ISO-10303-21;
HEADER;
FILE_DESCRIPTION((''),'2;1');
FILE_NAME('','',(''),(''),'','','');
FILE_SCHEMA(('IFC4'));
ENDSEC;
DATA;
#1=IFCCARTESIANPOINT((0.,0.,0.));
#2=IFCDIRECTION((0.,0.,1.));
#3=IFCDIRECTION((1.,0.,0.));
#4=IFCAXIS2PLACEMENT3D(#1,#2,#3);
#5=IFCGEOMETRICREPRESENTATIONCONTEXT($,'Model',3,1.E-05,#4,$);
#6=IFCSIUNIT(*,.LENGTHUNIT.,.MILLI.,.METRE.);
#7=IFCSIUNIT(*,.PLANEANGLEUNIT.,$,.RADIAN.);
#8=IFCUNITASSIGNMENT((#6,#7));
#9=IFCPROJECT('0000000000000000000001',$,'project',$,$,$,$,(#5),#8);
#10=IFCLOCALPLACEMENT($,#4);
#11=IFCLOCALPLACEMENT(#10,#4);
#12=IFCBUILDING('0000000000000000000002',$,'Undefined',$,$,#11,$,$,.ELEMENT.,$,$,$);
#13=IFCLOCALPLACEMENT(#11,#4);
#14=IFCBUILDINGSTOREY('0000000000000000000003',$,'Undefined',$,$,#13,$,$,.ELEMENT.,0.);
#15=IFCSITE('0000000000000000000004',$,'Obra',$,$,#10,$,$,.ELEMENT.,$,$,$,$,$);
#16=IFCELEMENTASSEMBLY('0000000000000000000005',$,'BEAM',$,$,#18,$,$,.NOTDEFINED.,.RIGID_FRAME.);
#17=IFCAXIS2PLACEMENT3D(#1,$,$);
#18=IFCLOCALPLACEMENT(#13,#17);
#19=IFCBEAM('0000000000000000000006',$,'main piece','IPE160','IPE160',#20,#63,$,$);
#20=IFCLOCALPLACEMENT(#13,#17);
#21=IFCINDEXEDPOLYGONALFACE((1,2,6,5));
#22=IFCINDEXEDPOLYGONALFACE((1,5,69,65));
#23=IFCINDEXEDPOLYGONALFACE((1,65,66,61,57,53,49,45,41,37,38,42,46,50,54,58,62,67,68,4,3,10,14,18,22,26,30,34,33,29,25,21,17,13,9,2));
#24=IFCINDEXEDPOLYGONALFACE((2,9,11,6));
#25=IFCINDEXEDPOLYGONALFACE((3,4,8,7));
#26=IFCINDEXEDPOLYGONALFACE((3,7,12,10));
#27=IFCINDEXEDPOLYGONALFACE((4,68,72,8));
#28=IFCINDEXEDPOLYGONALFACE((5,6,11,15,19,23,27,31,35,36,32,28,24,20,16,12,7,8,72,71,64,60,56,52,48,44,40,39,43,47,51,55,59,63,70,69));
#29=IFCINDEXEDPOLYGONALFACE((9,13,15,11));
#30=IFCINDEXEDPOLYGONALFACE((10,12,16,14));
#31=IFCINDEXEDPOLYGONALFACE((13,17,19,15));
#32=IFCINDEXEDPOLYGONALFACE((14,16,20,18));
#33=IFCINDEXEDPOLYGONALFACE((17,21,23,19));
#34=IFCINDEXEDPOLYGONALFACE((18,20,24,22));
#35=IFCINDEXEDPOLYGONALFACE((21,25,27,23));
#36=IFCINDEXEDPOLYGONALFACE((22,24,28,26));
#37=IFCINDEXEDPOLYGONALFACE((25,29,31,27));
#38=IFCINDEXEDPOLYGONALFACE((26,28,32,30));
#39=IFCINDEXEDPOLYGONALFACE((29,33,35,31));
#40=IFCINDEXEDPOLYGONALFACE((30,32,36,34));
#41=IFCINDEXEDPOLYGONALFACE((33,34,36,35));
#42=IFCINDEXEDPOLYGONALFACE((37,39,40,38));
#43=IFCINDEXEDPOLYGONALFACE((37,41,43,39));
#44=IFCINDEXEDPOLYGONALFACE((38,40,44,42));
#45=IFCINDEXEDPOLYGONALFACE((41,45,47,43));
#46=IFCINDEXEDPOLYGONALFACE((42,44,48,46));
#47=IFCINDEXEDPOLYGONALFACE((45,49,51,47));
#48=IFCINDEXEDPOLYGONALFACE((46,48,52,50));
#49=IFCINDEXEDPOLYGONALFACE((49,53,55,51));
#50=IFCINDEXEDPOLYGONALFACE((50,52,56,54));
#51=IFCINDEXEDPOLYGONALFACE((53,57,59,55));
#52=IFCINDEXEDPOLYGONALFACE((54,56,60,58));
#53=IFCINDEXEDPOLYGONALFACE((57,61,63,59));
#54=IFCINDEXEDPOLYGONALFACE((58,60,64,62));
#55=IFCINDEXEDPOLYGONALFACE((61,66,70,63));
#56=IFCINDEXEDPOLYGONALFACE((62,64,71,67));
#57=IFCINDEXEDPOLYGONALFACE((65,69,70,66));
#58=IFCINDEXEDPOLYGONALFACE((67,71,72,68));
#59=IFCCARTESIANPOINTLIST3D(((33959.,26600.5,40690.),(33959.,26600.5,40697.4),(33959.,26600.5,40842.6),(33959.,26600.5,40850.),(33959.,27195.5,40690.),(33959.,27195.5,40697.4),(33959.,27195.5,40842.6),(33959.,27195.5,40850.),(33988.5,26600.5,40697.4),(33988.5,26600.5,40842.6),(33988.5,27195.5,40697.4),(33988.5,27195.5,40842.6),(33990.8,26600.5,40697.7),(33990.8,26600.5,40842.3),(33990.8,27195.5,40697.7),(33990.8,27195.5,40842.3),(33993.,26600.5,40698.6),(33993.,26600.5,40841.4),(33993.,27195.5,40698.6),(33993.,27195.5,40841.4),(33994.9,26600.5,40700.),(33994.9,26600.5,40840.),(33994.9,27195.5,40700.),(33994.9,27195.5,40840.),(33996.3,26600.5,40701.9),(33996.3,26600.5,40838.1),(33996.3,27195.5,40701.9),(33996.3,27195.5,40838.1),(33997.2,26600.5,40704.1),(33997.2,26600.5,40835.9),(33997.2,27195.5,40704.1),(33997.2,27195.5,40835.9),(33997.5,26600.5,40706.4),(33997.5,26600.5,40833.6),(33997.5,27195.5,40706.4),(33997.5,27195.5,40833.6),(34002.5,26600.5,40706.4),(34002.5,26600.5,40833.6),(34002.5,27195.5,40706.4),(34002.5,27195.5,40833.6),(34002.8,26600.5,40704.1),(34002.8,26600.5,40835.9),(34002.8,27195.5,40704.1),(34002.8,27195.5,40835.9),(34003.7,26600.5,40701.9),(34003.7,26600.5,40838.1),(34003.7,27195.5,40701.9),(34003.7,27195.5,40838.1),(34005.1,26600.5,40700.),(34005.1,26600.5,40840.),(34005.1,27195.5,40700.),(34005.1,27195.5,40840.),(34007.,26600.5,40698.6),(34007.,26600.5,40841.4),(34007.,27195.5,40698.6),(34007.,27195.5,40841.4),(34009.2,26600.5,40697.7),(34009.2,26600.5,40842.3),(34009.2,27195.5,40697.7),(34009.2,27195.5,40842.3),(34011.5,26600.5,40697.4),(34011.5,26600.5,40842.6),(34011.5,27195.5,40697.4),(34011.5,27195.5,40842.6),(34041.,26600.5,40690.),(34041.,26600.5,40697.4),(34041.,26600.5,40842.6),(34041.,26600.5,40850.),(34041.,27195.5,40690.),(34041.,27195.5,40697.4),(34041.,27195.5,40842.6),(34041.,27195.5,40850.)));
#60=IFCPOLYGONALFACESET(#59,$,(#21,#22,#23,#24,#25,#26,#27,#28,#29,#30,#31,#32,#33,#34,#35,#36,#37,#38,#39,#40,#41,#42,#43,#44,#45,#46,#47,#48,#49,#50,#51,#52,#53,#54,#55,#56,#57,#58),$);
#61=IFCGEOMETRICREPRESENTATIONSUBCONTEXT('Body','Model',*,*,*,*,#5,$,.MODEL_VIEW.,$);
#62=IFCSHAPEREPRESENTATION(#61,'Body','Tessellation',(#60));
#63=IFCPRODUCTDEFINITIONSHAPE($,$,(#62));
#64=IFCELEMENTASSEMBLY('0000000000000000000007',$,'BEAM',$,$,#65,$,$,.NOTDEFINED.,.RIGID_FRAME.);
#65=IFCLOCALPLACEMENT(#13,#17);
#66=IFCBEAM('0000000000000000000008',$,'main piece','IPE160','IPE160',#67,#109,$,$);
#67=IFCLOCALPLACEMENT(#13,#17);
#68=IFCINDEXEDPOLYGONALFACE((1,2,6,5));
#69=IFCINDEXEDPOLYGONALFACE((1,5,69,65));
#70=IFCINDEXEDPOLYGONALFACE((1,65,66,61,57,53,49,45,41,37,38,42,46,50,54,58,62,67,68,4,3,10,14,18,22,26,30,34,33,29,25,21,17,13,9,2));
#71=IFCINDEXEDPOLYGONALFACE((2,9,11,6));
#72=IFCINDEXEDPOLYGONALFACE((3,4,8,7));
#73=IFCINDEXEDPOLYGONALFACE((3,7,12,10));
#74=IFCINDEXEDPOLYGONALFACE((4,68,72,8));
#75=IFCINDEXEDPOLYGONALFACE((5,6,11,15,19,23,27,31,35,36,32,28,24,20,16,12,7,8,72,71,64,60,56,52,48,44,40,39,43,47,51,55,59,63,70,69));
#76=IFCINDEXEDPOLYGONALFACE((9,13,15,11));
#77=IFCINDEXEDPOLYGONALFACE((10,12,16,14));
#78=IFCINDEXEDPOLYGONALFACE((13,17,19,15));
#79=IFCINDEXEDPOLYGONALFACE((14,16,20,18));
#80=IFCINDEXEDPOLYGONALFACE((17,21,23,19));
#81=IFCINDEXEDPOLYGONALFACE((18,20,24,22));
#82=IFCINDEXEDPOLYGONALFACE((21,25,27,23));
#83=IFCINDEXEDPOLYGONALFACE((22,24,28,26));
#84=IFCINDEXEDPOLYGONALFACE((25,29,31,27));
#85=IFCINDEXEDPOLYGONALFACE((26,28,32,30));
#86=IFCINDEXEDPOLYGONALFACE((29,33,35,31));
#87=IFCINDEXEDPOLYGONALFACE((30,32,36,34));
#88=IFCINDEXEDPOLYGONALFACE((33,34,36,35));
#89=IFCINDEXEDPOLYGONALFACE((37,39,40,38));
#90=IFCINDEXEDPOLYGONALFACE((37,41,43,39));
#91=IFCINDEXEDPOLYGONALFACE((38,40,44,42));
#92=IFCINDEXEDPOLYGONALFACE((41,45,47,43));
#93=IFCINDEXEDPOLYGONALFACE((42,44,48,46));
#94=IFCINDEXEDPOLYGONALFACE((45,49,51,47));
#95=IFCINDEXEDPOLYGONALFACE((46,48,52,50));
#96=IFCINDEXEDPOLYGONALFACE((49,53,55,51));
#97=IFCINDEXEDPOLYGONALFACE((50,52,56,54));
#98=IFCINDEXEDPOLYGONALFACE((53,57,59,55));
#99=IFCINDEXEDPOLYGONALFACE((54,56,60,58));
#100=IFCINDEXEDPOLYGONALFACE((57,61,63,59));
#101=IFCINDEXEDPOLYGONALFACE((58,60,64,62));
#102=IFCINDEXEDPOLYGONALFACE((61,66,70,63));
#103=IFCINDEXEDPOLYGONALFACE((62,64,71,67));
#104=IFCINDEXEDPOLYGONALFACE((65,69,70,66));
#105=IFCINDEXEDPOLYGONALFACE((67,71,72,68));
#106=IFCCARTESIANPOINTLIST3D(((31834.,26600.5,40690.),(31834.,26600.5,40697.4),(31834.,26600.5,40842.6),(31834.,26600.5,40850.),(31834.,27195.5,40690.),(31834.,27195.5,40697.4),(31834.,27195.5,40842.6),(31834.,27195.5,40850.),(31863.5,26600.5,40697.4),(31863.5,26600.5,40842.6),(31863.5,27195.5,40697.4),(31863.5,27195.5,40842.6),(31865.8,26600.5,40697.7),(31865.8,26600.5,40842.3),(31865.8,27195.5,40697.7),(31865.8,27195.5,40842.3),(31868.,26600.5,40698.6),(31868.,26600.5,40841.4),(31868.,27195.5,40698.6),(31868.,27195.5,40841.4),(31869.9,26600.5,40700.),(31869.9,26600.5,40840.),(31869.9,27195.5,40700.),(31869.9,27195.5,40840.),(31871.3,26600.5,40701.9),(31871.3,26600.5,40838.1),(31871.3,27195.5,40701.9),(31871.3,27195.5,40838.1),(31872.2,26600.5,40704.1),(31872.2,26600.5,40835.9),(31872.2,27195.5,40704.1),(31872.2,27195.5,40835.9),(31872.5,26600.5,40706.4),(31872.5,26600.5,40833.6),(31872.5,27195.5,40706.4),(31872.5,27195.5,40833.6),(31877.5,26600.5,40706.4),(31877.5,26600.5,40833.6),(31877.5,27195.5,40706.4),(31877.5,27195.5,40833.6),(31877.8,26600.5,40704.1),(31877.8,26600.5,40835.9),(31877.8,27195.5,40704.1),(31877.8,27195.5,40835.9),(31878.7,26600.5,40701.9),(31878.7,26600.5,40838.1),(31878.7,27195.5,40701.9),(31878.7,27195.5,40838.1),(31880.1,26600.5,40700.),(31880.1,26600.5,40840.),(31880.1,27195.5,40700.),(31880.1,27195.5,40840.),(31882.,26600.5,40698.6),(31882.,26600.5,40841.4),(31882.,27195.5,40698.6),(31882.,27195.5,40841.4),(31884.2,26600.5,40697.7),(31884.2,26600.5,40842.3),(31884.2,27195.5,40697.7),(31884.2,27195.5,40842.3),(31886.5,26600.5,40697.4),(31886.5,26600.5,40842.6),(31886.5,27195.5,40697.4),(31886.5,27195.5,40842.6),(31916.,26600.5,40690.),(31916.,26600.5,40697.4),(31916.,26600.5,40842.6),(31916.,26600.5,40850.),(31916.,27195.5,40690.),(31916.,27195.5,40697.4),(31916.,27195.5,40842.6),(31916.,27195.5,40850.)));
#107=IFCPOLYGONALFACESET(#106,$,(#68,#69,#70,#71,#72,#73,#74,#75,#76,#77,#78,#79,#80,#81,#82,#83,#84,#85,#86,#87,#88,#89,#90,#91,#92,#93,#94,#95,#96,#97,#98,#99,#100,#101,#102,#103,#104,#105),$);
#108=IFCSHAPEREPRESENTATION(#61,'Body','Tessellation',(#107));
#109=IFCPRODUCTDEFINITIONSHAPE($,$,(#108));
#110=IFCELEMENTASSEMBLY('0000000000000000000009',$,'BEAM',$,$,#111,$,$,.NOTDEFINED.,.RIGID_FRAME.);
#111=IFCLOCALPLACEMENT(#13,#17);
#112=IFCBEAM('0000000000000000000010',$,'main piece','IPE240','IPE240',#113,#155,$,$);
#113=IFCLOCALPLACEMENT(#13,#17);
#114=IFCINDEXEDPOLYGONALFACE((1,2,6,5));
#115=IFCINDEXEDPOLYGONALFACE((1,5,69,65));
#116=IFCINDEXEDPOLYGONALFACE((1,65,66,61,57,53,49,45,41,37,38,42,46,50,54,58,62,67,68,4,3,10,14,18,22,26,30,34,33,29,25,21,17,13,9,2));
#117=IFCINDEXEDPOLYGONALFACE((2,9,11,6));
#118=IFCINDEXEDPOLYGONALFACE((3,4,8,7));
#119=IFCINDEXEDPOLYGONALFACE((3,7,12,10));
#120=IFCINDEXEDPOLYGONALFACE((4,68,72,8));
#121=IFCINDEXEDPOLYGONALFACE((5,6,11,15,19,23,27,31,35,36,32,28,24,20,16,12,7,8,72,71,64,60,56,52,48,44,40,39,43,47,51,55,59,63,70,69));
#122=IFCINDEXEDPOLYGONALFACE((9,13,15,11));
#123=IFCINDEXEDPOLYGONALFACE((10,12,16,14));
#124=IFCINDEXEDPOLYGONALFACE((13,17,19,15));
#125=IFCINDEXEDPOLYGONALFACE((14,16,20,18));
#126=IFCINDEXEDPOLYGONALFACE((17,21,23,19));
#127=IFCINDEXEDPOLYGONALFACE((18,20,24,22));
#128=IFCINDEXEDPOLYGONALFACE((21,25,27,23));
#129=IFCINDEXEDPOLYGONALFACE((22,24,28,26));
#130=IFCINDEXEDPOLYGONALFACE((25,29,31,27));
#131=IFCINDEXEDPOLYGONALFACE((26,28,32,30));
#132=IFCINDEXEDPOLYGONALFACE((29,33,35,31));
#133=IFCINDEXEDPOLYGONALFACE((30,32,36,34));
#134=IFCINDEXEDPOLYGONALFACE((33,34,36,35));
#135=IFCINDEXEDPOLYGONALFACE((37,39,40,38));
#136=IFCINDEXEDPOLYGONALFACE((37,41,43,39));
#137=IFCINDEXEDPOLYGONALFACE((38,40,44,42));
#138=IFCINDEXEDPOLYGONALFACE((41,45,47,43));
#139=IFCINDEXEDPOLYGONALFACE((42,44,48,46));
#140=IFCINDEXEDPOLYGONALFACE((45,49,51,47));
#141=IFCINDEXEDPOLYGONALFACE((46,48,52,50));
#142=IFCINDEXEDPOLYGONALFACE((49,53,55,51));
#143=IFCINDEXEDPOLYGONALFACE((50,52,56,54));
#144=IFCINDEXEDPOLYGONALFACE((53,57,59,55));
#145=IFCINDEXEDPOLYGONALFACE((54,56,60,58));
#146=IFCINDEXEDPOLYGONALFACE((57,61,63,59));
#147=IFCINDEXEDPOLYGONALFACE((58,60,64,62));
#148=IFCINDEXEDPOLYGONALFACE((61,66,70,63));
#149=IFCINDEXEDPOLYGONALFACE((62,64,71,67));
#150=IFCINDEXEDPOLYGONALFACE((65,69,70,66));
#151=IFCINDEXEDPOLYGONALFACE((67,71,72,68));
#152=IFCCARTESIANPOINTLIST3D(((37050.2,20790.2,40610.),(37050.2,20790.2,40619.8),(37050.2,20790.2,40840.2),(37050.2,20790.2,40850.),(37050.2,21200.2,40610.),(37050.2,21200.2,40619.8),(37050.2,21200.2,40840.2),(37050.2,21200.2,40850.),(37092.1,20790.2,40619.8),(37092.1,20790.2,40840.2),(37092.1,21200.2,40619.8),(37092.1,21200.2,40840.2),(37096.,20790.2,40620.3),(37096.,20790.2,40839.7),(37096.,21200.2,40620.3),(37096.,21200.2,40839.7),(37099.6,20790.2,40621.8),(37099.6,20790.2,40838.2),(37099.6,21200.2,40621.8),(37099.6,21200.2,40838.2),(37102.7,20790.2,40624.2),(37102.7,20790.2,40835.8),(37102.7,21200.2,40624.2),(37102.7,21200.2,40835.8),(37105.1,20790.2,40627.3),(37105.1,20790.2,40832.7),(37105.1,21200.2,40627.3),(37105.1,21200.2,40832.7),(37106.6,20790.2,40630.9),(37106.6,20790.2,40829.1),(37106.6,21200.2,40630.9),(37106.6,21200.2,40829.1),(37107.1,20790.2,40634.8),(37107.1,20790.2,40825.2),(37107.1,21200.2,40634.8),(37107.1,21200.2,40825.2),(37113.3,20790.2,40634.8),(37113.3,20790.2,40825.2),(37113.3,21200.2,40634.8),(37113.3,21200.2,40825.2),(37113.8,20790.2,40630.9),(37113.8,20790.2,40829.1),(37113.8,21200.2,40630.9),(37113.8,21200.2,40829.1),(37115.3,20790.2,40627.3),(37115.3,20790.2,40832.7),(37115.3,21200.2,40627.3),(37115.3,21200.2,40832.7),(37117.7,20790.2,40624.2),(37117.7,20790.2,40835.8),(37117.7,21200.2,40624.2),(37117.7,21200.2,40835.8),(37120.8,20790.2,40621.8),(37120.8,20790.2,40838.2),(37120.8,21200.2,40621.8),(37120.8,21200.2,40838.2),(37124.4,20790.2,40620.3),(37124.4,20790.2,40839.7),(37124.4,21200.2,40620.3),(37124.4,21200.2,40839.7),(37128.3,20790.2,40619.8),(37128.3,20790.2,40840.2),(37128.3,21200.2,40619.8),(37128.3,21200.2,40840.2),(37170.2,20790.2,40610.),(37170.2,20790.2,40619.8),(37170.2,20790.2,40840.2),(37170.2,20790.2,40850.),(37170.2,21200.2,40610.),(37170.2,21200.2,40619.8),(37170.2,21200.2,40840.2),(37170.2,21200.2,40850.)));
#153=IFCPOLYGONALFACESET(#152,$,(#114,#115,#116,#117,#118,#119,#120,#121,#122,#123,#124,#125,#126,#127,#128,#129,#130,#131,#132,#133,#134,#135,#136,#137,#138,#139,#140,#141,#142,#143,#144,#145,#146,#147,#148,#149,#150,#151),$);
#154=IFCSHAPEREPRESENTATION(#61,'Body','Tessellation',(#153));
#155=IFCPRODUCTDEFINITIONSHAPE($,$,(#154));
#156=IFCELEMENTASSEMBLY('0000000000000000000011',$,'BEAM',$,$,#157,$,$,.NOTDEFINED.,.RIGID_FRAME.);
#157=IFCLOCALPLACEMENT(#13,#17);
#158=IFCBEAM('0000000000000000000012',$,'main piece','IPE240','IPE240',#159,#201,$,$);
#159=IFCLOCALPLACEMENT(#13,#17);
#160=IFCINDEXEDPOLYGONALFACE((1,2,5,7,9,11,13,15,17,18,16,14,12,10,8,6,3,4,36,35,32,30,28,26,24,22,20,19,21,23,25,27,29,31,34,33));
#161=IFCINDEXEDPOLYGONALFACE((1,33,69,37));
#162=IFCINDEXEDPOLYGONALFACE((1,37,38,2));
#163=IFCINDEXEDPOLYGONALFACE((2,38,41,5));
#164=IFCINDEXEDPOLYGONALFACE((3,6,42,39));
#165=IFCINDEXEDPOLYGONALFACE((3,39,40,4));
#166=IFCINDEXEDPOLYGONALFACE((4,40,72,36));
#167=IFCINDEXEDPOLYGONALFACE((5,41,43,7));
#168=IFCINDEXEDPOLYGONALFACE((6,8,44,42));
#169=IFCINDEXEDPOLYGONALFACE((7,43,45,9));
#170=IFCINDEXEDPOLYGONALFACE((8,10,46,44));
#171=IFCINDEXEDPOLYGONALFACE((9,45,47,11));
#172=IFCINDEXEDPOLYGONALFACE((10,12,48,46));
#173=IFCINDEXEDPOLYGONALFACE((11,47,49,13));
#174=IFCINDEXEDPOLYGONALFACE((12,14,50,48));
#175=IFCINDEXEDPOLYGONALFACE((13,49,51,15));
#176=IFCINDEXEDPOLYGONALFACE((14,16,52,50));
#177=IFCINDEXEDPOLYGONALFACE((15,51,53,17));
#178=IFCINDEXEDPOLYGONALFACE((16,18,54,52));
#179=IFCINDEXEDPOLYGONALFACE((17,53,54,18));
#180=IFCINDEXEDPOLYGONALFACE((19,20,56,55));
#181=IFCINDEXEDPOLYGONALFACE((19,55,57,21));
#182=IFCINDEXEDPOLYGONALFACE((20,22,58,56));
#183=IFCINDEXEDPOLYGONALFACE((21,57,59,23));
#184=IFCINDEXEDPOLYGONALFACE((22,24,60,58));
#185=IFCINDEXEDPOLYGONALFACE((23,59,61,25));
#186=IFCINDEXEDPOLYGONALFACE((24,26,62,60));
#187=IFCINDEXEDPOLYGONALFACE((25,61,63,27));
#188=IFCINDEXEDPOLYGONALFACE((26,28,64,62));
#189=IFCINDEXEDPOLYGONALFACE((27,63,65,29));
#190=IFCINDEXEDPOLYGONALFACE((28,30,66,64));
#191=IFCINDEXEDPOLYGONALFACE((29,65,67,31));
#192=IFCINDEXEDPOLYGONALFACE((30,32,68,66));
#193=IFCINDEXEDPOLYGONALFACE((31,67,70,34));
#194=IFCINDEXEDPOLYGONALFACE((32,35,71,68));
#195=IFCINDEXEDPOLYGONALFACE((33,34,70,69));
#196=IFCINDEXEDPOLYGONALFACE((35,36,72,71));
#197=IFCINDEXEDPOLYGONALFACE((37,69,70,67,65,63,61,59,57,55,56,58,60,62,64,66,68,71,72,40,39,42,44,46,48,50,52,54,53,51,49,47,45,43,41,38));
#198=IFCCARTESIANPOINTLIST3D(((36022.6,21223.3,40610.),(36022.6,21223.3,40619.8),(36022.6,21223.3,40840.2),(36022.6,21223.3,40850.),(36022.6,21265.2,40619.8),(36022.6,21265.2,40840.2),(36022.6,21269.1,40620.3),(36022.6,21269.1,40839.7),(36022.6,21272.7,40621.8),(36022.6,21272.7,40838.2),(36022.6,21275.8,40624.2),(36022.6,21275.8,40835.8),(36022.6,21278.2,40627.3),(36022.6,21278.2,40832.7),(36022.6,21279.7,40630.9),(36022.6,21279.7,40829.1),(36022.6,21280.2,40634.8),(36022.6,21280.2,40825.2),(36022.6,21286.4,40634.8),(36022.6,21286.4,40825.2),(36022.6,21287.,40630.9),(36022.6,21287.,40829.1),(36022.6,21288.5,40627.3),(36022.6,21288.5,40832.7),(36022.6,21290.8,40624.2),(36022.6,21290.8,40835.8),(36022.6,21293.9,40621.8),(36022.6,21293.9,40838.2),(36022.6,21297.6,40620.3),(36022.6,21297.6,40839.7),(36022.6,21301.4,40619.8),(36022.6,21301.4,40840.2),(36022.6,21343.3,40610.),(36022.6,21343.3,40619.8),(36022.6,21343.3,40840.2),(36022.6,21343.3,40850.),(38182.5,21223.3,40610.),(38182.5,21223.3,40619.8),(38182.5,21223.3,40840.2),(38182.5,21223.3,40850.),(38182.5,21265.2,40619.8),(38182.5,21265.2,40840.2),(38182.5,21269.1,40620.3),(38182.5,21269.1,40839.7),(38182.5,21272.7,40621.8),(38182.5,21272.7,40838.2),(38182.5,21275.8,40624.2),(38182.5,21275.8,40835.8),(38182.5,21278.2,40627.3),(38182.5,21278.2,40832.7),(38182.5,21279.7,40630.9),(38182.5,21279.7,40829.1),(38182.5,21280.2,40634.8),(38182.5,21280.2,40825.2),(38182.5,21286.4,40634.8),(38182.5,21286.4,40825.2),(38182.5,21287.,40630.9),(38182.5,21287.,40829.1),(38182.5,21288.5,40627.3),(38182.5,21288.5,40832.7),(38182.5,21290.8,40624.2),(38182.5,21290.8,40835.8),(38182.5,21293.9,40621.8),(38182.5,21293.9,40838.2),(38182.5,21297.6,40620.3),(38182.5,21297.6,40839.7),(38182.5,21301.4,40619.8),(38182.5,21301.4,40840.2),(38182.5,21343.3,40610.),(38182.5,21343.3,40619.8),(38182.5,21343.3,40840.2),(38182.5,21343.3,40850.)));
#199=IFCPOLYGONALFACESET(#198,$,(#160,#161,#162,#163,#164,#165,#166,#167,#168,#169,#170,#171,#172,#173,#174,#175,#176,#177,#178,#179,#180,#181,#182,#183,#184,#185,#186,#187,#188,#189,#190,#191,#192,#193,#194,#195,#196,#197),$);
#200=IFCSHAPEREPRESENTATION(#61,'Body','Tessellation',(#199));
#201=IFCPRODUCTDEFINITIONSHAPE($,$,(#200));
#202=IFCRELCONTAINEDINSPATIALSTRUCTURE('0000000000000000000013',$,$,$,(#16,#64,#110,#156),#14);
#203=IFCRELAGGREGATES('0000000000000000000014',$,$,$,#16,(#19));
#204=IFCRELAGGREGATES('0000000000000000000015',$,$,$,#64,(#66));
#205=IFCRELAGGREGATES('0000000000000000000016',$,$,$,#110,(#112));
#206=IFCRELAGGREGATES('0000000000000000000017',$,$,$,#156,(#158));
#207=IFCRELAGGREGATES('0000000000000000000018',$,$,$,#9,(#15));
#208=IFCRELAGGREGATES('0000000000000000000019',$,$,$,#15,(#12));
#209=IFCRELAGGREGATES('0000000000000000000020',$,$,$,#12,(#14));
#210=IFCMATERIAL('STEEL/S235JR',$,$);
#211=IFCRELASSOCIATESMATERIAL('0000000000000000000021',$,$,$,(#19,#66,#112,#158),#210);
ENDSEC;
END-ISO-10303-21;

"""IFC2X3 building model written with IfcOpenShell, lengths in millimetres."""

from ifc_helpers import new_model, si_unit, frame, origin_with_axes, origin_2d_with_axis, place, context, subcontext, project, spatial, i_section, extrude, material, element, aggregate, save


model = new_model("IFC2X3")

# Units and contexts
model_context = context("Model", 3, precision=1e-05, world=origin_with_axes())
body_context = subcontext(model_context, "Body", "Model", "MODEL_VIEW")
ifc_project = project(units=[si_unit("LENGTHUNIT", "METRE", prefix="MILLI"), si_unit("PLANEANGLEUNIT", "RADIAN")], contexts=[model_context])

# Site, building, storey
site_placement = place(None, origin_with_axes())
site = spatial("IfcSite", under=ifc_project, at=site_placement, Name="Obra", CompositionType="ELEMENT")
building_placement = place(site_placement, origin_with_axes())
building = spatial("IfcBuilding", under=site, at=building_placement, Name="Undefined", CompositionType="ELEMENT")
storey_placement = place(building_placement, origin_with_axes())
storey = spatial("IfcBuildingStorey", under=building, at=storey_placement, Name="Undefined", CompositionType="ELEMENT", Elevation=0.0)

# Element assemblies, beams
ifc_material_1 = material(Name="STEEL/S235JR")
assembly_1_placement = place(storey_placement, origin_with_axes())
assembly_1 = element("IfcElementAssembly", 1, at=assembly_1_placement, inside=storey, Name="BEAM", AssemblyPlace="NOTDEFINED", PredefinedType="RIGID_FRAME")
beam_1_placement = place(assembly_1_placement, frame((34000.0, 26600.5, 40770.0), z_axis=(0.0, 0.0, 1.0), x_axis=(0.0, 1.0, 0.0)))
beam_1 = element("IfcBeam", 2, at=beam_1_placement, material=ifc_material_1, Name="main piece", Description="IPE160", ObjectType="IPE160", context=body_context, shape_type="SweptSolid", body=[
    extrude(i_section(OverallWidth=82.0, OverallDepth=160.0, WebThickness=5.0, FlangeThickness=7.4, FilletRadius=9.0, at=origin_2d_with_axis()), frame((595.1, 0.0, 0.0), z_axis=(-1.0, 0.0, 0.0), x_axis=(0.0, -1.0, 0.0)), (0.0, 0.0, 1.0), 595.0),
])
aggregate(assembly_1, [beam_1])
assembly_2_placement = place(storey_placement, origin_with_axes())
assembly_2 = element("IfcElementAssembly", 3, at=assembly_2_placement, inside=storey, Name="BEAM", AssemblyPlace="NOTDEFINED", PredefinedType="RIGID_FRAME")
beam_2_placement = place(assembly_2_placement, frame((31875.0, 26600.5, 40770.0), z_axis=(0.0, 0.0, 1.0), x_axis=(0.0, 1.0, 0.0)))
beam_2 = element("IfcBeam", 4, at=beam_2_placement, material=ifc_material_1, Name="main piece", Description="IPE160", ObjectType="IPE160", context=body_context, shape_type="SweptSolid", body=[
    extrude(i_section(OverallWidth=82.0, OverallDepth=160.0, WebThickness=5.0, FlangeThickness=7.4, FilletRadius=9.0, at=origin_2d_with_axis()), frame((595.0, 0.0, 0.0), z_axis=(-1.0, 0.0, 0.0), x_axis=(0.0, -1.0, 0.0)), (0.0, 0.0, 1.0), 595.0),
])
aggregate(assembly_2, [beam_2])
assembly_3_placement = place(storey_placement, origin_with_axes())
assembly_3 = element("IfcElementAssembly", 5, at=assembly_3_placement, inside=storey, Name="BEAM", AssemblyPlace="NOTDEFINED", PredefinedType="RIGID_FRAME")
beam_3_placement = place(assembly_3_placement, frame((37110.2, 20790.2, 40730.0), z_axis=(0.0, 0.0, 1.0), x_axis=(0.0, 1.0, 0.0)))
beam_3 = element("IfcBeam", 6, at=beam_3_placement, material=ifc_material_1, Name="main piece", Description="IPE240", ObjectType="IPE240", context=body_context, shape_type="SweptSolid", body=[
    extrude(i_section(OverallWidth=120.0, OverallDepth=240.0, WebThickness=6.2, FlangeThickness=9.8, FilletRadius=15.0, at=origin_2d_with_axis()), frame((410.0, 0.0, 0.0), z_axis=(-1.0, 0.0, 0.0), x_axis=(0.0, -1.0, 0.0)), (0.0, 0.0, 1.0), 410.0),
])
aggregate(assembly_3, [beam_3])
assembly_4_placement = place(storey_placement, origin_with_axes())
assembly_4 = element("IfcElementAssembly", 7, at=assembly_4_placement, inside=storey, Name="BEAM", AssemblyPlace="NOTDEFINED", PredefinedType="RIGID_FRAME")
beam_4_placement = place(assembly_4_placement, frame((36022.6, 21283.3, 40730.0), z_axis=(0.0, 0.0, 1.0), x_axis=(1.0, 0.0, 0.0)))
beam_4 = element("IfcBeam", 8, at=beam_4_placement, material=ifc_material_1, Name="main piece", Description="IPE240", ObjectType="IPE240", context=body_context, shape_type="SweptSolid", body=[
    extrude(i_section(OverallWidth=120.0, OverallDepth=240.0, WebThickness=6.2, FlangeThickness=9.8, FilletRadius=15.0, at=origin_2d_with_axis()), frame((2159.9, 0.0, 0.0), z_axis=(-1.0, 0.0, 0.0), x_axis=(0.0, -1.0, 0.0)), (0.0, 0.0, 1.0), 2159.9),
])
aggregate(assembly_4, [beam_4])

save(model, "model.ifc")
